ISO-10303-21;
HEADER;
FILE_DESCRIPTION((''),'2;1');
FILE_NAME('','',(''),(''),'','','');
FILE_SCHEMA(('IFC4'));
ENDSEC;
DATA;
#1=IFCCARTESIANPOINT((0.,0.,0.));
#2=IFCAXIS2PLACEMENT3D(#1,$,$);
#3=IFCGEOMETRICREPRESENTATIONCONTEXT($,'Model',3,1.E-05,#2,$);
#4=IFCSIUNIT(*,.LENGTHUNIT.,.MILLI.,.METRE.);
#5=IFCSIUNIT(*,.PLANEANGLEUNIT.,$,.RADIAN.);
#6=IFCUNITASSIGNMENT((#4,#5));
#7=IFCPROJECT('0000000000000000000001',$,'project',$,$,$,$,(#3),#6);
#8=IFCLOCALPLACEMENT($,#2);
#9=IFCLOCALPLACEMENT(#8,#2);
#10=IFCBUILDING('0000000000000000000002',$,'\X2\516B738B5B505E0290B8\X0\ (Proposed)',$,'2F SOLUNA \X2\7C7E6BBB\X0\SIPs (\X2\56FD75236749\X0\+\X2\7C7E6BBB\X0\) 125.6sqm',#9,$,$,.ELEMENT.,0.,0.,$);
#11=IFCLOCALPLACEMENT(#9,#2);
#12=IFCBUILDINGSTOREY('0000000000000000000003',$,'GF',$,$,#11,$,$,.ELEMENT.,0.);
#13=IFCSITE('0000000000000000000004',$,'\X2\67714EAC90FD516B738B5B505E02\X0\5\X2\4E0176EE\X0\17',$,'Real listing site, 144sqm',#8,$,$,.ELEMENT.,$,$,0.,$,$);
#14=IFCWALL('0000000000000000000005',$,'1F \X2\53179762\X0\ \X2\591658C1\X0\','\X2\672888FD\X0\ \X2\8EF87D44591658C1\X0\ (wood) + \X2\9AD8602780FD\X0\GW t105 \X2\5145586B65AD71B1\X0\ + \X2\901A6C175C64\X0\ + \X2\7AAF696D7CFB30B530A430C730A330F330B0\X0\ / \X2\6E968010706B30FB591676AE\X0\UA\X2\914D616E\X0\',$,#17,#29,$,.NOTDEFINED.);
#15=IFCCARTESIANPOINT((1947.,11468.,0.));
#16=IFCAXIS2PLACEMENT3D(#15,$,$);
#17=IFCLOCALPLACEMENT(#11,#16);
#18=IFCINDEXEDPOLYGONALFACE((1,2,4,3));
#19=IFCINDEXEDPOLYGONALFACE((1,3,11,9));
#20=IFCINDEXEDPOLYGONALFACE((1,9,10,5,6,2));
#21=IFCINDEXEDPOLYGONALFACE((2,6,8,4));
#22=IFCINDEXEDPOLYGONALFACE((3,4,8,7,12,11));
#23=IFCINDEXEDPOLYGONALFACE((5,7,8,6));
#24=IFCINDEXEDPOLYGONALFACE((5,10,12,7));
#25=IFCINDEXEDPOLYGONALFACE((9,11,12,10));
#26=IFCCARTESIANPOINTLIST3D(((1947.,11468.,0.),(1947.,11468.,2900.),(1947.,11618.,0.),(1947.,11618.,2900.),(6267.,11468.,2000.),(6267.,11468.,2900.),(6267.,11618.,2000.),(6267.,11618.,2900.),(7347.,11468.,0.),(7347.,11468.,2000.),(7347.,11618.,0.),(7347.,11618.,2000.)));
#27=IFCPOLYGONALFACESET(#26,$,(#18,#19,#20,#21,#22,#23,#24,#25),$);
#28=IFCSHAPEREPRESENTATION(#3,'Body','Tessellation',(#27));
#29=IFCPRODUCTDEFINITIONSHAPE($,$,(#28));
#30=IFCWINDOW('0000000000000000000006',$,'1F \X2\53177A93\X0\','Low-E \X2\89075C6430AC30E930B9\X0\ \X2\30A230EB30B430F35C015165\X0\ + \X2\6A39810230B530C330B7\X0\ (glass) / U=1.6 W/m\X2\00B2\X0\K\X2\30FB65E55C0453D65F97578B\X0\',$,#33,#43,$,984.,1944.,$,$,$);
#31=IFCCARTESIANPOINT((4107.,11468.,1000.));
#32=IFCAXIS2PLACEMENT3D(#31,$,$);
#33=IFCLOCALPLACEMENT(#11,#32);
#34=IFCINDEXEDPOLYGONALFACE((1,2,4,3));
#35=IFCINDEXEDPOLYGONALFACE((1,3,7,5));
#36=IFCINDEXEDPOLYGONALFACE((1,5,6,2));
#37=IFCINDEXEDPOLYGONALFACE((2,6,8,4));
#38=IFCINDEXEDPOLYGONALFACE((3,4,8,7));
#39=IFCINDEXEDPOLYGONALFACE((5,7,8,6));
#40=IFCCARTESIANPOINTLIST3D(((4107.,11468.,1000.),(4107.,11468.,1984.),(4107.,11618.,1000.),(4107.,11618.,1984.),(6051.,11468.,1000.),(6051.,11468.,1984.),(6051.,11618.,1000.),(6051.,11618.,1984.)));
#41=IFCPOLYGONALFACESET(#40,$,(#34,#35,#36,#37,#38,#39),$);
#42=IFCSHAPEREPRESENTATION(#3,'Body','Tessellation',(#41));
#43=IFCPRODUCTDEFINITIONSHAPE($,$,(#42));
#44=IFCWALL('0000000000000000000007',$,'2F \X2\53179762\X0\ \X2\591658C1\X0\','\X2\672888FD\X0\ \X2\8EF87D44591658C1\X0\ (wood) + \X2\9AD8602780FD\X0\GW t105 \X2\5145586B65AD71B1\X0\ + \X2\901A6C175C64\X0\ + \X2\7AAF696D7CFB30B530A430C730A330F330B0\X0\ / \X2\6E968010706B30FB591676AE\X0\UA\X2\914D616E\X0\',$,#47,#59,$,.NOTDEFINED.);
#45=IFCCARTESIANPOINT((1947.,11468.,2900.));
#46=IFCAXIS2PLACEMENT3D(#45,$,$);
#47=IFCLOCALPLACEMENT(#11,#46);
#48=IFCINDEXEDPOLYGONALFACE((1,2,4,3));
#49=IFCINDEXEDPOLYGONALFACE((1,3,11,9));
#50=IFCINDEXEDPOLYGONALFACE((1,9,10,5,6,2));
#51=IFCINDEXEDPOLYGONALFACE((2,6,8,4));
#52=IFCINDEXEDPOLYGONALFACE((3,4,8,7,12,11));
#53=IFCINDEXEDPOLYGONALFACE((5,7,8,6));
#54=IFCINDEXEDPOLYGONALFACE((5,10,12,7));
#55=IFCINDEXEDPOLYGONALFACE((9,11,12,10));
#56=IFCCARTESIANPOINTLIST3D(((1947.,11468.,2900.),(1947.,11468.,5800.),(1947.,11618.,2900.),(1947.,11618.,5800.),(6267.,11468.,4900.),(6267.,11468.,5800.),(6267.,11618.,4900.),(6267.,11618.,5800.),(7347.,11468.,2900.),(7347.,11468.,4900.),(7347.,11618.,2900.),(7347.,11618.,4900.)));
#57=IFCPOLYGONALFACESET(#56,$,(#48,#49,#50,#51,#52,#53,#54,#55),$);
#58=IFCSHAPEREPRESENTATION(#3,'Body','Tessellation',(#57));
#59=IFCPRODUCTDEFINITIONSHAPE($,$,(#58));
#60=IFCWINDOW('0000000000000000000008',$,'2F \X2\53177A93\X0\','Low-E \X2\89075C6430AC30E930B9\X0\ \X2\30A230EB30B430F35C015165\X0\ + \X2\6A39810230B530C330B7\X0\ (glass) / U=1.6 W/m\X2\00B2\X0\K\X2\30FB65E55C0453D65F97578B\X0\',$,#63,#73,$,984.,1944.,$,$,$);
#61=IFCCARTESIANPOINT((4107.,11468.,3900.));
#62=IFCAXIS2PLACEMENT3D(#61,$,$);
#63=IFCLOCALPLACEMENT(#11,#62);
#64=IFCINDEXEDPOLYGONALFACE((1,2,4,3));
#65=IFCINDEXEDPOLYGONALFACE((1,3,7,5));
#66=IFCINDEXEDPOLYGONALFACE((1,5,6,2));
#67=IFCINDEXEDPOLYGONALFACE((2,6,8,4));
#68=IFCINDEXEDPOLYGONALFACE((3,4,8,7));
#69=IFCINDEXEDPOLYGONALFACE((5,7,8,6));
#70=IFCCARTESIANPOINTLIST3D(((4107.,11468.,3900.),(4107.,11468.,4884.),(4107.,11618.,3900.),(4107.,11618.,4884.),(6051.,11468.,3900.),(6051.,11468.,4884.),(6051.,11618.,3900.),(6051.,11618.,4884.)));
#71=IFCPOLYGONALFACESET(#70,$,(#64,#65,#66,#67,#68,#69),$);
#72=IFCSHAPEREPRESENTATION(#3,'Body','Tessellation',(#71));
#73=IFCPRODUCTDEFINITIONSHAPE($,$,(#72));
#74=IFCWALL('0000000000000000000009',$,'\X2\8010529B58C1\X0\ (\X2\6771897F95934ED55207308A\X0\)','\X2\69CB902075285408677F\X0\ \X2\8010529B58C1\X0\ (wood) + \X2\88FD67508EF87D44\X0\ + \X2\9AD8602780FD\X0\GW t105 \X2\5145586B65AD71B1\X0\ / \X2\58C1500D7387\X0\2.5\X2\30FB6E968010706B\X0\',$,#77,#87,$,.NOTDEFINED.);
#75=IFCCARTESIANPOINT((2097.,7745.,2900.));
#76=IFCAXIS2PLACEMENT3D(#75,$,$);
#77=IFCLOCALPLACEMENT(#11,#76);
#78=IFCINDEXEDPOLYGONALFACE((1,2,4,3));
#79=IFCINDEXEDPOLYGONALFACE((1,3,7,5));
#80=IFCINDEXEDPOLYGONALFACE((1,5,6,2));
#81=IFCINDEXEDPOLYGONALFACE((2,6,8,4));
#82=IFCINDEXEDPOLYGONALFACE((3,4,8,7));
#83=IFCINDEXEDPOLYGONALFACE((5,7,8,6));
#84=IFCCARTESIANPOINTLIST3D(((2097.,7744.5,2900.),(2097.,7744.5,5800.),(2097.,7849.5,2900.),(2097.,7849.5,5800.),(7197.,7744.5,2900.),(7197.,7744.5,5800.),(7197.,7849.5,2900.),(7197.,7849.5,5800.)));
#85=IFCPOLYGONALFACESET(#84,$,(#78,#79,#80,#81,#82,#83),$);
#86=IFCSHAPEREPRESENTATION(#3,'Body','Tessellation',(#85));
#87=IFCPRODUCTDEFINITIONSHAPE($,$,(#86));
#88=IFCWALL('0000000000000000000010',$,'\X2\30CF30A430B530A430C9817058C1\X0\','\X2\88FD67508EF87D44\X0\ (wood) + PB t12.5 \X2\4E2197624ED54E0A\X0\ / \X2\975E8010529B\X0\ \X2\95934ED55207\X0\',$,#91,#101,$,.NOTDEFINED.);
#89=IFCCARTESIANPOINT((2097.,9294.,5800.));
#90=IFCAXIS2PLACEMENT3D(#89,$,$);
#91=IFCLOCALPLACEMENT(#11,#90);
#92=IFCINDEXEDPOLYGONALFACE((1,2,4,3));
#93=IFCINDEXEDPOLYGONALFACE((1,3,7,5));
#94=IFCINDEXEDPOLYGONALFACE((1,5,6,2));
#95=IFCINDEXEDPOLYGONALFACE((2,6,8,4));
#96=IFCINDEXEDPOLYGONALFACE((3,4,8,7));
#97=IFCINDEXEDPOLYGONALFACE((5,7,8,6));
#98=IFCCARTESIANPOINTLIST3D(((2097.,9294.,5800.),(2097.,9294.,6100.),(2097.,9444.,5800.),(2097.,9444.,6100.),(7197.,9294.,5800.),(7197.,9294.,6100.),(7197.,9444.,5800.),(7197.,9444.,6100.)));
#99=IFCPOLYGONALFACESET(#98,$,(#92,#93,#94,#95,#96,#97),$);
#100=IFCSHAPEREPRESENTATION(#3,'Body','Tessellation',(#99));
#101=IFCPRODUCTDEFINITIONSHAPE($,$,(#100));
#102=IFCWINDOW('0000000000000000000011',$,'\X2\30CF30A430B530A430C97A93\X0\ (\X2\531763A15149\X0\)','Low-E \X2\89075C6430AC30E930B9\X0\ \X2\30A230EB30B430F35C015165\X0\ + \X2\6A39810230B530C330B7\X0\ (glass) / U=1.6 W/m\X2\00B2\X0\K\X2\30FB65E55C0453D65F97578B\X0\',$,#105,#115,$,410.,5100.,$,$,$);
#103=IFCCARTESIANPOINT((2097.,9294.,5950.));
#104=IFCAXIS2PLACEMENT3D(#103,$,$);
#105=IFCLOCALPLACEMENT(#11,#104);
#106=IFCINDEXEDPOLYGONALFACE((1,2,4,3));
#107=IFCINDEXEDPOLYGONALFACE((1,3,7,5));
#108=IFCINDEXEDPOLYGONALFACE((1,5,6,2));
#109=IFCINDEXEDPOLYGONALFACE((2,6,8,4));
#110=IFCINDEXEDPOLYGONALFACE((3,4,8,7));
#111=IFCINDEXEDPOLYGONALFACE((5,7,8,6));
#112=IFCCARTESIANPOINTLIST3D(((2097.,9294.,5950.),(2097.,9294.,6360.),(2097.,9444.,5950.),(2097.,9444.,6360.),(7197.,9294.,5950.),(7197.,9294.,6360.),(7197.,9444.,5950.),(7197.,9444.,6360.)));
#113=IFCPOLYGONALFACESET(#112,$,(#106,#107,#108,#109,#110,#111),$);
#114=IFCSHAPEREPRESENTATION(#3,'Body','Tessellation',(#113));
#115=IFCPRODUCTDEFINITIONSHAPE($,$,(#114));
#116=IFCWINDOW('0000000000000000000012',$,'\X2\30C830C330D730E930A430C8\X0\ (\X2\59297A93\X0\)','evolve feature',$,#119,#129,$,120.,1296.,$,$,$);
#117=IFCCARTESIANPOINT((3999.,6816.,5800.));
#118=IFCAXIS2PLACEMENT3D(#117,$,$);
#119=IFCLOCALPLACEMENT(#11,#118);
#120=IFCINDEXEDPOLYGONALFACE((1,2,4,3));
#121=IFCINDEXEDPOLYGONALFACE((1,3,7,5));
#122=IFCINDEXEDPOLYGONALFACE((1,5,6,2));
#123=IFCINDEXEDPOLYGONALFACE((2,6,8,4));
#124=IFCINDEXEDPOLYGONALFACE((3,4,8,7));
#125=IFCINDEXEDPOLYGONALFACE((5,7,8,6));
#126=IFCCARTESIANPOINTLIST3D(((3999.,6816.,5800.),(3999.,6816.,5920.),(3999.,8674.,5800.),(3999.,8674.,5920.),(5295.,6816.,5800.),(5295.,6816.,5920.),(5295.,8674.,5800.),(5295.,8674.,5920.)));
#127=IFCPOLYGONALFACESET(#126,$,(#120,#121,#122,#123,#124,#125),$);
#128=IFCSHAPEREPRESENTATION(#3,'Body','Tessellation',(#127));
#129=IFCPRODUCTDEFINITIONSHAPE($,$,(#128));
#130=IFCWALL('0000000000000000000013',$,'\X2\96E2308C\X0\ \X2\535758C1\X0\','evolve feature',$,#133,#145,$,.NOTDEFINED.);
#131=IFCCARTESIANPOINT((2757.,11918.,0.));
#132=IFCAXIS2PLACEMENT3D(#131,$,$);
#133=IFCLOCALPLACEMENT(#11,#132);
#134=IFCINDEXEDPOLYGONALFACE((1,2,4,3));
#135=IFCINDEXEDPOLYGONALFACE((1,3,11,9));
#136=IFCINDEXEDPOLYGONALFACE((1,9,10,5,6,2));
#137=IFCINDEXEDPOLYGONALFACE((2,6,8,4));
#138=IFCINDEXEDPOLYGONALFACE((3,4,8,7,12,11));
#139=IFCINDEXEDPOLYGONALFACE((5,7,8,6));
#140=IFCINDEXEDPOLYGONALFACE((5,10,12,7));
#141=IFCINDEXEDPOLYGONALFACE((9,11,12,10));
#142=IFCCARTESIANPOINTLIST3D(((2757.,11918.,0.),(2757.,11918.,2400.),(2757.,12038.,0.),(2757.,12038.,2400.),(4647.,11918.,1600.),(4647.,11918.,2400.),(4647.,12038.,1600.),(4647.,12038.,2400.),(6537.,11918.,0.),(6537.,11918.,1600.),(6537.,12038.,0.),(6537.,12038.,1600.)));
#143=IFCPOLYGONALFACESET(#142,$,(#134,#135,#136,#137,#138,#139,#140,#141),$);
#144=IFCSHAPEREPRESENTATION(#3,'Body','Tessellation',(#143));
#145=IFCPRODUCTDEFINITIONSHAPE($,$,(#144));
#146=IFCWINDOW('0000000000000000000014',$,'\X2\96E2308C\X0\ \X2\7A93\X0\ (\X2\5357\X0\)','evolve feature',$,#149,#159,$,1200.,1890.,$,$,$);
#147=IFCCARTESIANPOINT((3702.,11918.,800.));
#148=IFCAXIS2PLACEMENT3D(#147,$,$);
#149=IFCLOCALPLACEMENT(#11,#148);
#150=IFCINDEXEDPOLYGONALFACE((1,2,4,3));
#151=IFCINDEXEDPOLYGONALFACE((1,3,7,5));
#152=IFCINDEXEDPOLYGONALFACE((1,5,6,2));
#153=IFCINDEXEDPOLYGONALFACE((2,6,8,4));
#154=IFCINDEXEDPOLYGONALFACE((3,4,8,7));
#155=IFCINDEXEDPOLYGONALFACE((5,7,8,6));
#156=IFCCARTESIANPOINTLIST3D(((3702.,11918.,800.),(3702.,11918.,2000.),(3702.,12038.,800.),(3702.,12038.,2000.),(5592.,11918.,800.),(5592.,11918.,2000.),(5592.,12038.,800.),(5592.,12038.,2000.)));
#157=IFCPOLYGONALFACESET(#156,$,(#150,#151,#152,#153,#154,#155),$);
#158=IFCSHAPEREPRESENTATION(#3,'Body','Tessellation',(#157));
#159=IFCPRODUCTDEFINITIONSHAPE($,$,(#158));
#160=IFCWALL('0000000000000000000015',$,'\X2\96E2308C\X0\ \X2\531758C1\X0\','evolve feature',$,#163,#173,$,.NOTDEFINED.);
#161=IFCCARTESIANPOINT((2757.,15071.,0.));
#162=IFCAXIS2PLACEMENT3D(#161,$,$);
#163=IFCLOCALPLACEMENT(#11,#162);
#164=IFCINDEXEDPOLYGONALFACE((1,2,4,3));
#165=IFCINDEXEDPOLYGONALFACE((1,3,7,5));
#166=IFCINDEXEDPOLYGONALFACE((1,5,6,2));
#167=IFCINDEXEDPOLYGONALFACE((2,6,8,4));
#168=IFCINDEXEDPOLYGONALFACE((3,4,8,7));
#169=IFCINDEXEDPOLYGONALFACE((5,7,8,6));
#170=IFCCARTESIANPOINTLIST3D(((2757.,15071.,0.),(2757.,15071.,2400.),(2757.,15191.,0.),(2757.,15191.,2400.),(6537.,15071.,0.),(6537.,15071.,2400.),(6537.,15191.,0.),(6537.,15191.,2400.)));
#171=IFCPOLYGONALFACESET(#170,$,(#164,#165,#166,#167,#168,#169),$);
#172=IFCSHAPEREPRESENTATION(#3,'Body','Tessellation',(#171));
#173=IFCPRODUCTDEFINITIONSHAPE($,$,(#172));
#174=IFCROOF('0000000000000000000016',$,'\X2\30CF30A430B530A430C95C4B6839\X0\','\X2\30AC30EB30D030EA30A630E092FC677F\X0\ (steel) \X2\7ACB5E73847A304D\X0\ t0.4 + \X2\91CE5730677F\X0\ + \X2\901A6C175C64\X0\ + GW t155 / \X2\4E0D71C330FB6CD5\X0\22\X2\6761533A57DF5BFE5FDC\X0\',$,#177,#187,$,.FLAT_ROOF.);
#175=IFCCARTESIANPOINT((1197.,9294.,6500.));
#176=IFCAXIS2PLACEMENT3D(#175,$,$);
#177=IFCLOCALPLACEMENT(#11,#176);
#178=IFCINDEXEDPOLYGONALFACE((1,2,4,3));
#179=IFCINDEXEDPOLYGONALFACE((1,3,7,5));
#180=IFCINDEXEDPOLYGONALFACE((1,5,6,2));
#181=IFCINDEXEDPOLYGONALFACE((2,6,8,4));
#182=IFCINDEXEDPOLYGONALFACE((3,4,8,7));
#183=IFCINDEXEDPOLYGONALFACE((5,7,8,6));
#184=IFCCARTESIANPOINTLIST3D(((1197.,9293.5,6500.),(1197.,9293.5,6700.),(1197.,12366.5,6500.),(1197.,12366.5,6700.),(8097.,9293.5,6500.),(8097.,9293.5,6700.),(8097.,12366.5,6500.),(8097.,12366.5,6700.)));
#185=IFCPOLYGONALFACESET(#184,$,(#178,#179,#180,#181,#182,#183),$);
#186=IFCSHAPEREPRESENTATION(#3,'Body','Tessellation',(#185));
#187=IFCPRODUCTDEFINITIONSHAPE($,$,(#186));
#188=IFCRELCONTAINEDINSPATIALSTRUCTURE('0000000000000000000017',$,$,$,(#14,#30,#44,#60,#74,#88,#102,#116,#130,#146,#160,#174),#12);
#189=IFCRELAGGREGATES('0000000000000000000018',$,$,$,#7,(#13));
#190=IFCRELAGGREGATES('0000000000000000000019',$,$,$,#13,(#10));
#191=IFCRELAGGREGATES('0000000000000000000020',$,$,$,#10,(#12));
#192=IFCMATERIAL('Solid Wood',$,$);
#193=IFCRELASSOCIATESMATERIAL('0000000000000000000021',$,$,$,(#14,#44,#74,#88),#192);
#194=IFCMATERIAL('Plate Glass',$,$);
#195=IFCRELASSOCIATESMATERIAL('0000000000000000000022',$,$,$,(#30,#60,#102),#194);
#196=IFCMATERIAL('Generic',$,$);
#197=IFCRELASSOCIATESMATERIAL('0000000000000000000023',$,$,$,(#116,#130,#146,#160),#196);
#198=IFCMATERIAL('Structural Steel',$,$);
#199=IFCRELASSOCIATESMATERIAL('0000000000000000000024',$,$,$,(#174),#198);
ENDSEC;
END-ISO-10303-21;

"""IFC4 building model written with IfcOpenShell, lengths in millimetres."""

from ifc_helpers import new_model, si_unit, frame, frame_2d, origin, place, context, project, spatial, rectangle, extrude, material, element, fill, save


model = new_model("IFC4")

# Units and contexts
model_context = context("Model", 3, precision=1e-05, world=origin())
ifc_project = project(units=[si_unit("LENGTHUNIT", "METRE", prefix="MILLI"), si_unit("PLANEANGLEUNIT", "RADIAN")], contexts=[model_context])

# Site, building, storey
site_placement = place(None, origin())
site = spatial("IfcSite", under=ifc_project, at=site_placement, Name="東京都八王子市5丁目17", ObjectType="Real listing site, 144sqm", CompositionType="ELEMENT", RefElevation=0.0)
building_placement = place(site_placement, origin())
building = spatial("IfcBuilding", under=site, at=building_placement, Name="八王子市邸 (Proposed)", ObjectType="2F SOLUNA 籾殻SIPs (国産杉+籾殻) 125.6sqm", CompositionType="ELEMENT", ElevationOfRefHeight=0.0, ElevationOfTerrain=0.0)
storey_placement = place(building_placement, origin())
storey = spatial("IfcBuildingStorey", under=building, at=storey_placement, Name="GF", CompositionType="ELEMENT", Elevation=0.0)

# Shared definitions
ifc_material_1 = material(Name="Generic")

# Wall, opening, window
ifc_material_2 = material(Name="Solid Wood")
wall_1_placement = place(storey_placement, frame((1947.0, 11468.0, 0.0)))
wall_1 = element("IfcWall", 1, at=wall_1_placement, inside=storey, material=ifc_material_2, Name="1F 北面 外壁", Description="木製 軸組外壁 (wood) + 高性能GW t105 充填断熱 + 通気層 + 窯業系サイディング / 準耐火・外皮UA配慮", PredefinedType="NOTDEFINED", context=model_context, shape_type="SweptSolid", body=[
    extrude(rectangle(XDim=5400.0, YDim=150.0, at=frame_2d((2700.0, 75.0))), frame((1947.0, 11468.0, 0.0)), (0.0, 0.0, 1.0), 2900.0),
])
opening_1_placement = place(storey_placement, frame((4107.0, 11468.0, 1000.0)))
opening_1 = element("IfcOpeningElement", 2, at=opening_1_placement, cuts=wall_1, PredefinedType="NOTDEFINED", context=model_context, shape_type="SweptSolid", body=[
    extrude(rectangle(XDim=1944.0, YDim=150.0, at=frame_2d((972.0, 75.0))), frame((4107.0, 11468.0, 1000.0)), (0.0, 0.0, 1.0), 984.0),
])
ifc_material_3 = material(Name="Plate Glass")
window_1_placement = place(storey_placement, frame((4107.0, 11468.0, 1000.0)))
window_1 = element("IfcWindow", 3, at=window_1_placement, inside=storey, material=ifc_material_3, Name="1F 北窓", Description="Low-E 複層ガラス アルゴン封入 + 樹脂サッシ (glass) / U=1.6 W/m²K・日射取得型", OverallHeight=984.0, OverallWidth=1944.0, context=model_context, shape_type="SweptSolid", body=[
    extrude(rectangle(XDim=1944.0, YDim=150.0, at=frame_2d((972.0, 75.0))), frame((4107.0, 11468.0, 1000.0)), (0.0, 0.0, 1.0), 984.0),
])
fill(opening_1, window_1)

# Wall, opening, window
wall_2_placement = place(storey_placement, frame((1947.0, 11468.0, 2900.0)))
wall_2 = element("IfcWall", 4, at=wall_2_placement, inside=storey, material=ifc_material_2, Name="2F 北面 外壁", Description="木製 軸組外壁 (wood) + 高性能GW t105 充填断熱 + 通気層 + 窯業系サイディング / 準耐火・外皮UA配慮", PredefinedType="NOTDEFINED", context=model_context, shape_type="SweptSolid", body=[
    extrude(rectangle(XDim=5400.0, YDim=150.0, at=frame_2d((2700.0, 75.0))), frame((1947.0, 11468.0, 2900.0)), (0.0, 0.0, 1.0), 2900.0),
])
opening_2_placement = place(storey_placement, frame((4107.0, 11468.0, 3900.0)))
opening_2 = element("IfcOpeningElement", 5, at=opening_2_placement, cuts=wall_2, PredefinedType="NOTDEFINED", context=model_context, shape_type="SweptSolid", body=[
    extrude(rectangle(XDim=1944.0, YDim=150.0, at=frame_2d((972.0, 75.0))), frame((4107.0, 11468.0, 3900.0)), (0.0, 0.0, 1.0), 984.0),
])
window_2_placement = place(storey_placement, frame((4107.0, 11468.0, 3900.0)))
window_2 = element("IfcWindow", 6, at=window_2_placement, inside=storey, material=ifc_material_3, Name="2F 北窓", Description="Low-E 複層ガラス アルゴン封入 + 樹脂サッシ (glass) / U=1.6 W/m²K・日射取得型", OverallHeight=984.0, OverallWidth=1944.0, context=model_context, shape_type="SweptSolid", body=[
    extrude(rectangle(XDim=1944.0, YDim=150.0, at=frame_2d((972.0, 75.0))), frame((4107.0, 11468.0, 3900.0)), (0.0, 0.0, 1.0), 984.0),
])
fill(opening_2, window_2)

# Wall
wall_3_placement = place(storey_placement, frame((2097.0, 7745.0, 2900.0)))
element("IfcWall", 7, at=wall_3_placement, inside=storey, material=ifc_material_2, Name="耐力壁 (東西間仕切り)", Description="構造用合板 耐力壁 (wood) + 製材軸組 + 高性能GW t105 充填断熱 / 壁倍率2.5・準耐火", PredefinedType="NOTDEFINED", context=model_context, shape_type="SweptSolid", body=[
    extrude(rectangle(XDim=5100.0, YDim=105.0, at=frame_2d((2550.0, 52.0))), frame((2097.0, 7745.0, 2900.0)), (0.0, 0.0, 1.0), 2900.0),
])

# Wall, opening, window
wall_4_placement = place(storey_placement, frame((2097.0, 9294.0, 5800.0)))
wall_4 = element("IfcWall", 8, at=wall_4_placement, inside=storey, material=ifc_material_2, Name="ハイサイド腰壁", Description="製材軸組 (wood) + PB t12.5 両面仕上 / 非耐力 間仕切", PredefinedType="NOTDEFINED", context=model_context, shape_type="SweptSolid", body=[
    extrude(rectangle(XDim=5100.0, YDim=150.0, at=frame_2d((2550.0, 75.0))), frame((2097.0, 9294.0, 5800.0)), (0.0, 0.0, 1.0), 700.0),
])
opening_3_placement = place(storey_placement, frame((2097.0, 9294.0, 5950.0)))
opening_3 = element("IfcOpeningElement", 9, at=opening_3_placement, cuts=wall_4, PredefinedType="NOTDEFINED", context=model_context, shape_type="SweptSolid", body=[
    extrude(rectangle(XDim=5100.0, YDim=150.0, at=frame_2d((2550.0, 75.0))), frame((2097.0, 9294.0, 5950.0)), (0.0, 0.0, 1.0), 410.0),
])
window_3_placement = place(storey_placement, frame((2097.0, 9294.0, 5950.0)))
window_3 = element("IfcWindow", 10, at=window_3_placement, inside=storey, material=ifc_material_3, Name="ハイサイド窓 (北採光)", Description="Low-E 複層ガラス アルゴン封入 + 樹脂サッシ (glass) / U=1.6 W/m²K・日射取得型", OverallHeight=410.0, OverallWidth=5100.0, context=model_context, shape_type="SweptSolid", body=[
    extrude(rectangle(XDim=5100.0, YDim=150.0, at=frame_2d((2550.0, 75.0))), frame((2097.0, 9294.0, 5950.0)), (0.0, 0.0, 1.0), 410.0),
])
fill(opening_3, window_3)

# Window
window_4_placement = place(storey_placement, frame((3999.0, 6816.0, 5800.0)))
element("IfcWindow", 11, at=window_4_placement, inside=storey, material=ifc_material_1, Name="トップライト (天窓)", Description="evolve feature", OverallHeight=120.0, OverallWidth=1296.0, context=model_context, shape_type="SweptSolid", body=[
    extrude(rectangle(XDim=1296.0, YDim=1858.0, at=frame_2d((648.0, 929.0))), frame((3999.0, 6816.0, 5800.0)), (0.0, 0.0, 1.0), 120.0),
])

# Wall, opening, window
wall_5_placement = place(storey_placement, frame((2757.0, 11918.0, 0.0)))
wall_5 = element("IfcWall", 12, at=wall_5_placement, inside=storey, material=ifc_material_1, Name="離れ 南壁", Description="evolve feature", PredefinedType="NOTDEFINED", context=model_context, shape_type="SweptSolid", body=[
    extrude(rectangle(XDim=3780.0, YDim=120.0, at=frame_2d((1890.0, 60.0))), frame((2757.0, 11918.0, 0.0)), (0.0, 0.0, 1.0), 2400.0),
])
opening_4_placement = place(storey_placement, frame((3702.0, 11918.0, 800.0)))
opening_4 = element("IfcOpeningElement", 13, at=opening_4_placement, cuts=wall_5, PredefinedType="NOTDEFINED", context=model_context, shape_type="SweptSolid", body=[
    extrude(rectangle(XDim=1890.0, YDim=120.0, at=frame_2d((945.0, 60.0))), frame((3702.0, 11918.0, 800.0)), (0.0, 0.0, 1.0), 1200.0),
])
window_5_placement = place(storey_placement, frame((3702.0, 11918.0, 800.0)))
window_5 = element("IfcWindow", 14, at=window_5_placement, inside=storey, material=ifc_material_1, Name="離れ 窓 (南)", Description="evolve feature", OverallHeight=1200.0, OverallWidth=1890.0, context=model_context, shape_type="SweptSolid", body=[
    extrude(rectangle(XDim=1890.0, YDim=120.0, at=frame_2d((945.0, 60.0))), frame((3702.0, 11918.0, 800.0)), (0.0, 0.0, 1.0), 1200.0),
])
fill(opening_4, window_5)

# Wall
wall_6_placement = place(storey_placement, frame((2757.0, 15071.0, 0.0)))
element("IfcWall", 15, at=wall_6_placement, inside=storey, material=ifc_material_1, Name="離れ 北壁", Description="evolve feature", PredefinedType="NOTDEFINED", context=model_context, shape_type="SweptSolid", body=[
    extrude(rectangle(XDim=3780.0, YDim=120.0, at=frame_2d((1890.0, 60.0))), frame((2757.0, 15071.0, 0.0)), (0.0, 0.0, 1.0), 2400.0),
])

# Roof
ifc_material_4 = material(Name="Structural Steel")
roof_1_placement = place(storey_placement, frame((1197.0, 9294.0, 6500.0)))
element("IfcRoof", 16, at=roof_1_placement, inside=storey, material=ifc_material_4, Name="ハイサイド屋根", Description="ガルバリウム鋼板 (steel) 立平葺き t0.4 + 野地板 + 通気層 + GW t155 / 不燃・法22条区域対応", PredefinedType="FLAT_ROOF", context=model_context, shape_type="SweptSolid", body=[
    extrude(rectangle(XDim=6900.0, YDim=3073.0, at=frame_2d((3450.0, 1536.0))), frame((1197.0, 9294.0, 6500.0)), (0.0, 0.0, 1.0), 200.0),
])

save(model, "model.ifc")
